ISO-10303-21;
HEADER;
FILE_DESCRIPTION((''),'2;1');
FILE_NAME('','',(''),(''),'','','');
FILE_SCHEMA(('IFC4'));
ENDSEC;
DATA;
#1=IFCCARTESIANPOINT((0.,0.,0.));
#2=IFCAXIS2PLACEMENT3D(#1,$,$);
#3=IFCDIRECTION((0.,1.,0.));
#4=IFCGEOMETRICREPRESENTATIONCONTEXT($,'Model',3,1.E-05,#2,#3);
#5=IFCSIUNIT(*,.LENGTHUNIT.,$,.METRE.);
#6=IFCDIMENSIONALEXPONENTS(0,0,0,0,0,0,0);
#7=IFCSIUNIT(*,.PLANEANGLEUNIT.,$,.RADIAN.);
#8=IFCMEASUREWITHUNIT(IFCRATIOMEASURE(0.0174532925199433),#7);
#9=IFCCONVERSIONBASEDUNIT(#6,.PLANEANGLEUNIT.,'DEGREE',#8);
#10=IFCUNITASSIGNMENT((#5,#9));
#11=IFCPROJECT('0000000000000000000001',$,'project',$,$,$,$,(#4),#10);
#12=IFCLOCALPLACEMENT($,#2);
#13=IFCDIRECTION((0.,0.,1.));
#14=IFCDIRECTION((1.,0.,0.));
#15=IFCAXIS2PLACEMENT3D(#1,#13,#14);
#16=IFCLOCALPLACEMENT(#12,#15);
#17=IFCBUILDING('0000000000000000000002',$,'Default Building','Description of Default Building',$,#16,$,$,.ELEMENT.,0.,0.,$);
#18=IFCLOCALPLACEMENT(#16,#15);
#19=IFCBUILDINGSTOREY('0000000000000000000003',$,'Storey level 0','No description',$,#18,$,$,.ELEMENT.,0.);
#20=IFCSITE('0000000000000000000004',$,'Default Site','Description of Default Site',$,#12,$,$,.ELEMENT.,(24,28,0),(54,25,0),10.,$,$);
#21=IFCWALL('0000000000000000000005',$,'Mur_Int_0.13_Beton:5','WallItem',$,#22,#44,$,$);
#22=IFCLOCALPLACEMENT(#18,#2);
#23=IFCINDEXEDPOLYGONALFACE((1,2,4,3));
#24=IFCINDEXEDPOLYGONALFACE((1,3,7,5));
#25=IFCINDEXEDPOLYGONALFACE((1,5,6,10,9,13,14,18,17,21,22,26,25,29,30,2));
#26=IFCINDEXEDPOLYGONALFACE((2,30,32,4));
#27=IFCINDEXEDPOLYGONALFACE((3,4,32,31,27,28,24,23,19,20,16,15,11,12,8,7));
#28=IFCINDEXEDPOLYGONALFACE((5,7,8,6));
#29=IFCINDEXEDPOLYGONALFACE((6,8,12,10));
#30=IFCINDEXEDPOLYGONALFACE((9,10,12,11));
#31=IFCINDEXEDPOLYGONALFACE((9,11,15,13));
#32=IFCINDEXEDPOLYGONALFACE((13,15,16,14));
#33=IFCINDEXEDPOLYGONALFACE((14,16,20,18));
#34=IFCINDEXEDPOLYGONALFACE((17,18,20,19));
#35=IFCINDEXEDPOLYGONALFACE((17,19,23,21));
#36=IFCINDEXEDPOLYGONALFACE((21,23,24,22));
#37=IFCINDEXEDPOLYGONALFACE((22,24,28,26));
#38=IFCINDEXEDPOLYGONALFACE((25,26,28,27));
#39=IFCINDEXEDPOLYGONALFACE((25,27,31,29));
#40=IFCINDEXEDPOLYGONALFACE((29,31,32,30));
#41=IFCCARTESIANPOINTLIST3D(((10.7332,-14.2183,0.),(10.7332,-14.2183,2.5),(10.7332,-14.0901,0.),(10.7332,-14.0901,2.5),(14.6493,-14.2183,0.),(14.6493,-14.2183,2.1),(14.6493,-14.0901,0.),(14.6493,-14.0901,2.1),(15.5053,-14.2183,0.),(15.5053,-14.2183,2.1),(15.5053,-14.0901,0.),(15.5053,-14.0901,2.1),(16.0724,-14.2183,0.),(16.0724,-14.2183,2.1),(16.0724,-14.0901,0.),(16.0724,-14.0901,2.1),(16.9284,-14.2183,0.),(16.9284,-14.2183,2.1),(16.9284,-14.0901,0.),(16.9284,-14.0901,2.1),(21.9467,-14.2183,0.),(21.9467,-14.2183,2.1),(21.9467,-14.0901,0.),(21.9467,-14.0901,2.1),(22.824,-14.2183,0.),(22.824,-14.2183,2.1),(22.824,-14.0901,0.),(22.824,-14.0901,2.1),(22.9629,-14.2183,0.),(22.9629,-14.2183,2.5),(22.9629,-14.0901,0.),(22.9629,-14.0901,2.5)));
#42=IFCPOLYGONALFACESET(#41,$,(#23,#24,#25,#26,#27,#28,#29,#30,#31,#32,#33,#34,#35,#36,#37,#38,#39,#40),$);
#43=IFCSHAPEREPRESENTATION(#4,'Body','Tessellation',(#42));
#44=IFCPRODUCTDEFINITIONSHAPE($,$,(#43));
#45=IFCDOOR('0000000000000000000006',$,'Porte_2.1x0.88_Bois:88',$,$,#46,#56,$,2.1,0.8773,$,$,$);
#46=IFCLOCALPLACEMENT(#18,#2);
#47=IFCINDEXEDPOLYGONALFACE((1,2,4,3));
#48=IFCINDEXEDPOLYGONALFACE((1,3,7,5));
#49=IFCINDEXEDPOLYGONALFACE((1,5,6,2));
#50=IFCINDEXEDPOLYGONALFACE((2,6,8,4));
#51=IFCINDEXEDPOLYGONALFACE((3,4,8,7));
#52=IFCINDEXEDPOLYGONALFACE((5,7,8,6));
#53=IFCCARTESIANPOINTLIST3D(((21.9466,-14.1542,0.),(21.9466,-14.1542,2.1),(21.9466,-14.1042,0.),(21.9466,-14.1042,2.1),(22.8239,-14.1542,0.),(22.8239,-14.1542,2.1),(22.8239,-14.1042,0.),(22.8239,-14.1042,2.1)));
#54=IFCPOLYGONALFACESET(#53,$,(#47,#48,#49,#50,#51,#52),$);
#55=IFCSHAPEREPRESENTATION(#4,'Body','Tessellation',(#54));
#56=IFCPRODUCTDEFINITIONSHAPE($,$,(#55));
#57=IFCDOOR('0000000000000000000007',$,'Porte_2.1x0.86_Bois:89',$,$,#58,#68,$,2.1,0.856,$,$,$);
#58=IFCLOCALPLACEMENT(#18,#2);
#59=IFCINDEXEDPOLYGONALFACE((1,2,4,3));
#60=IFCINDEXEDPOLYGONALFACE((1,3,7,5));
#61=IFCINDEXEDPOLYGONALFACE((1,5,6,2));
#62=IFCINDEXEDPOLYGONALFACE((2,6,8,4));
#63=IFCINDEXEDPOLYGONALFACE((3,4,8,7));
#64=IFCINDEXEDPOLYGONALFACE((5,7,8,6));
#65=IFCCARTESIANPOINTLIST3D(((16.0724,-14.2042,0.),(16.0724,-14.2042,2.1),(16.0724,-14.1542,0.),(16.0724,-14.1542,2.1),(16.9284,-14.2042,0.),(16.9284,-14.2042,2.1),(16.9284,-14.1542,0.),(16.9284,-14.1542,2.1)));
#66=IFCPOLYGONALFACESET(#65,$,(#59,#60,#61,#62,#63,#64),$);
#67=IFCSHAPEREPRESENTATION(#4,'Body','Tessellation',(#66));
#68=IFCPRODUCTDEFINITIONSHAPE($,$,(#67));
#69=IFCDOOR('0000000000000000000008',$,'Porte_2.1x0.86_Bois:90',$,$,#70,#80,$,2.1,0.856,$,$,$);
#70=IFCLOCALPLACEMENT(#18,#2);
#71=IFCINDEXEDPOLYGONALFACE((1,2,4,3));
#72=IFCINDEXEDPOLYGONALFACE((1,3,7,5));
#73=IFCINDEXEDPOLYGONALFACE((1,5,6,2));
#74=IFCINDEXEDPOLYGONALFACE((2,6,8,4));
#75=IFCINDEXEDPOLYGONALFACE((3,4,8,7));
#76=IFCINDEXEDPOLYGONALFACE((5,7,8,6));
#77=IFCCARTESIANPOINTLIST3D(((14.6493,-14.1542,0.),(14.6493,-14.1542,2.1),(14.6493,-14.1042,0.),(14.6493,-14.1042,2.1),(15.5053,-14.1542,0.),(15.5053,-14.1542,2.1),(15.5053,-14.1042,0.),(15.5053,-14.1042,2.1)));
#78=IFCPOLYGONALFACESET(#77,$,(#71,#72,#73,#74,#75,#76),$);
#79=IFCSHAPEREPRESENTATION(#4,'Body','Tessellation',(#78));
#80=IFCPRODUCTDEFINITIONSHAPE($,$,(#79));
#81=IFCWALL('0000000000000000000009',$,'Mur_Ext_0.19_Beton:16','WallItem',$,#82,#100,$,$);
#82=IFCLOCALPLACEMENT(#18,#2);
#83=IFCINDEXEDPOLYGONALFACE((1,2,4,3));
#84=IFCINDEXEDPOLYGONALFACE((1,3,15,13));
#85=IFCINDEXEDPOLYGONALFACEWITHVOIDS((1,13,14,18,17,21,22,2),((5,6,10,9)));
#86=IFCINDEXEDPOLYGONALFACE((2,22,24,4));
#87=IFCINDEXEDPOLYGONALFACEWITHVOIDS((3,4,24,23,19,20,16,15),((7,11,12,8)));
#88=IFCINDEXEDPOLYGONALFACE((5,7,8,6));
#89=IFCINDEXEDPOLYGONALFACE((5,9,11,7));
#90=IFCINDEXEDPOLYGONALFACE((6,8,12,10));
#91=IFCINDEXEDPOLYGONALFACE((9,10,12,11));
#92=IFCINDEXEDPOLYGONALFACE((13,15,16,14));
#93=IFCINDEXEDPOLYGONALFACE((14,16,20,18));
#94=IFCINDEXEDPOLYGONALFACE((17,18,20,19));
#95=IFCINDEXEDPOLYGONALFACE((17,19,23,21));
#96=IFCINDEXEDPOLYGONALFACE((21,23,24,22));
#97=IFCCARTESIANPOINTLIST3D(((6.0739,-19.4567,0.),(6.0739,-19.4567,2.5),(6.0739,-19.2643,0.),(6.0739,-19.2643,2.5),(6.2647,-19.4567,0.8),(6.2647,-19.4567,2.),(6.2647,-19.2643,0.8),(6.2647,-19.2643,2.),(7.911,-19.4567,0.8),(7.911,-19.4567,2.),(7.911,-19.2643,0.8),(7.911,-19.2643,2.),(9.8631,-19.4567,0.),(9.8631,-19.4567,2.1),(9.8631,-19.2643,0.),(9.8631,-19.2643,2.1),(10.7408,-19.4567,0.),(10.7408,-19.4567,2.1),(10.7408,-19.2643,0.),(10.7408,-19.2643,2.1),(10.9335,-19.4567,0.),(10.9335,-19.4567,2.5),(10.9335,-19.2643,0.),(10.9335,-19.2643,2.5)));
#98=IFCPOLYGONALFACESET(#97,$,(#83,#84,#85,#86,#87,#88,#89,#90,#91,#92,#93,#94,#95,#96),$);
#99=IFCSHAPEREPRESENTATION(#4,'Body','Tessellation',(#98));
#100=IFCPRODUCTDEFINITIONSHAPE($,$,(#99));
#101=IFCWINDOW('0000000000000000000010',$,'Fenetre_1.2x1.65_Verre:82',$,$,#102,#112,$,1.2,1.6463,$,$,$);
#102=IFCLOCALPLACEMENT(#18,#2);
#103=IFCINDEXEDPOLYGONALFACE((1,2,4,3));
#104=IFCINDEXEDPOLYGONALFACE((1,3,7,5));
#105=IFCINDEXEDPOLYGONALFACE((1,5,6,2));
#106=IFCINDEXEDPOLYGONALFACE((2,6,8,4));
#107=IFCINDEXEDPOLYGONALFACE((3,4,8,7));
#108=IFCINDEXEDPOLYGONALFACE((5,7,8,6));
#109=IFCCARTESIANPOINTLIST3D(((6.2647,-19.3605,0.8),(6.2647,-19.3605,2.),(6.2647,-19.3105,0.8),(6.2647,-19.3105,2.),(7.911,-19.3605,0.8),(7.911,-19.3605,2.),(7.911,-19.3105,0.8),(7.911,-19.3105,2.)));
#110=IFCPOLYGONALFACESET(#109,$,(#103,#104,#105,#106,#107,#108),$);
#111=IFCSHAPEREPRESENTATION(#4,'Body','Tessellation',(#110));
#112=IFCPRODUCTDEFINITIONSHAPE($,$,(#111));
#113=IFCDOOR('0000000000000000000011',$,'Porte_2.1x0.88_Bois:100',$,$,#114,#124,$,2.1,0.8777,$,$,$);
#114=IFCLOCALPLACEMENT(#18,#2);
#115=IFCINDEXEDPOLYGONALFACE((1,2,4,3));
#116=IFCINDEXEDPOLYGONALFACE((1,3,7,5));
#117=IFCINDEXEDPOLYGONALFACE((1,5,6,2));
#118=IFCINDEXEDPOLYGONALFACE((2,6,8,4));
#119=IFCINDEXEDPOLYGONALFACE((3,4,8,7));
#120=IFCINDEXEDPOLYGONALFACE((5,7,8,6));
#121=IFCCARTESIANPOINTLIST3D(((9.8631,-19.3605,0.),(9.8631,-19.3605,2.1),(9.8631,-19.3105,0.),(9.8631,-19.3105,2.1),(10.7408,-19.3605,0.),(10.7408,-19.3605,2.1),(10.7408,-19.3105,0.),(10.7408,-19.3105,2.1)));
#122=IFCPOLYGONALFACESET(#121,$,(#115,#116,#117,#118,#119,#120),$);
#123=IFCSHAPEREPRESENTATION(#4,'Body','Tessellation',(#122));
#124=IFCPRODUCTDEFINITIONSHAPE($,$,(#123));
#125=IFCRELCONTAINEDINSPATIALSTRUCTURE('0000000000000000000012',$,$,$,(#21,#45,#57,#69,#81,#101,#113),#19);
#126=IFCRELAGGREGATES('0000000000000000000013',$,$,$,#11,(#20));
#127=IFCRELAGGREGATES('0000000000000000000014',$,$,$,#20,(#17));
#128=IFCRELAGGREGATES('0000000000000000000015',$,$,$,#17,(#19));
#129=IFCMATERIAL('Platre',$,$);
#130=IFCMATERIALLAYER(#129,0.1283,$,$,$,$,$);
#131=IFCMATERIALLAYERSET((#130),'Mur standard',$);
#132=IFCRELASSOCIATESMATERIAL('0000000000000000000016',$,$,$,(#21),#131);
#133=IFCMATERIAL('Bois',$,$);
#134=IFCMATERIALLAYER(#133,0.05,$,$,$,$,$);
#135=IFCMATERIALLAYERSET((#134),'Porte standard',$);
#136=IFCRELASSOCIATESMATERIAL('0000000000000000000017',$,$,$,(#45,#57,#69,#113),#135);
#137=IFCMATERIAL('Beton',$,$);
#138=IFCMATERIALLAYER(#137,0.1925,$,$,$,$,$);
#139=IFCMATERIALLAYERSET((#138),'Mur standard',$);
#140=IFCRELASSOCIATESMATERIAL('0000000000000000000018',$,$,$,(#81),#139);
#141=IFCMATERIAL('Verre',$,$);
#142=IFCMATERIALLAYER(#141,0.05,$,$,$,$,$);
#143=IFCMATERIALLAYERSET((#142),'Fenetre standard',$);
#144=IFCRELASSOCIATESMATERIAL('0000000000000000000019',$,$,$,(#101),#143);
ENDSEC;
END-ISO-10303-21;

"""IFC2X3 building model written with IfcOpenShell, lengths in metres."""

from ifc_helpers import new_model, entity, si_unit, converted_unit, direction, frame, origin, origin_with_axes, place, context, project, spatial, polyline, outline, extrude, material, layer, layer_set, layer_usage, element, fill, save


model = new_model("IFC2X3")

# Units and contexts
model_context = context("Model", 3, precision=1e-05, world=origin(), true_north=direction((0.0, 1.0, 0.0)))
ifc_project = project(units=[si_unit("LENGTHUNIT", "METRE"), converted_unit("PLANEANGLEUNIT", "DEGREE", entity("IfcRatioMeasure", 0.0174532925199433), si_unit("PLANEANGLEUNIT", "RADIAN"), dimensions=[0, 0, 0, 0, 0, 0, 0])], contexts=[model_context])

# Site, building, storey
site_placement = place(None, origin())
site = spatial("IfcSite", under=ifc_project, at=site_placement, Name="Default Site", Description="Description of Default Site", CompositionType="ELEMENT", RefLatitude=(24, 28, 0), RefLongitude=(54, 25, 0), RefElevation=10.0)
building_placement = place(site_placement, origin_with_axes())
building = spatial("IfcBuilding", under=site, at=building_placement, Name="Default Building", Description="Description of Default Building", CompositionType="ELEMENT", ElevationOfRefHeight=0.0, ElevationOfTerrain=0.0)
storey_placement = place(building_placement, origin_with_axes())
storey = spatial("IfcBuildingStorey", under=building, at=storey_placement, Name="Storey level 0", Description="No description", CompositionType="ELEMENT", Elevation=0.0)

# Wall, openings, doors
ifc_material_1 = material(Name="Platre")
ifc_layer_1 = layer(ifc_material_1, 0.1283)
ifc_layer_set_1 = layer_set([ifc_layer_1], Name="Mur standard")
ifc_layer_usage_1 = layer_usage(ifc_layer_set_1, "AXIS2", "NEGATIVE", 0.1283)
wall_1_placement = place(storey_placement, frame((10.7332, -14.1542, 0.0), z_axis=(0.0, 0.0, 1.0), x_axis=(1.0, 0.0, 0.0)))
wall_1 = element("IfcWall", 1, at=wall_1_placement, inside=storey, material=ifc_layer_usage_1, Name="Mur_Int_0.13_Beton:5", Description="WallItem", context=model_context, shape_type="SweptSolid", body=[
    extrude(outline(polyline([(0.0, 0.0641), (0.0, -0.0641), (12.2297, -0.0641), (12.2297, 0.0641), (0.0, 0.0641)])), origin(), (0.0, 0.0, 1.0), 2.5),
])
opening_1_placement = place(storey_placement, frame((22.824, -14.09, 0.0), z_axis=(0.0, 0.0, 1.0), x_axis=(-1.0, 0.0, 0.0)))
opening_1 = element("IfcOpeningElement", 2, at=opening_1_placement, cuts=wall_1, context=model_context, shape_type="SweptSolid", body=[
    extrude(outline(polyline([(0.8773, 0.1783), (0.0, 0.1783), (0.0, -0.05), (0.8773, -0.05), (0.8773, 0.1783)])), origin(), (0.0, 0.0, 1.0), 2.1),
])
opening_2_placement = place(storey_placement, frame((16.0724, -14.09, 0.0), z_axis=(0.0, 0.0, 1.0), x_axis=(1.0, 0.0, 0.0)))
opening_2 = element("IfcOpeningElement", 3, at=opening_2_placement, cuts=wall_1, context=model_context, shape_type="SweptSolid", body=[
    extrude(outline(polyline([(0.0, -0.1783), (0.856, -0.1783), (0.856, 0.05), (0.0, 0.05), (0.0, -0.1783)])), origin(), (0.0, 0.0, 1.0), 2.1),
])
opening_3_placement = place(storey_placement, frame((15.5053, -14.09, 0.0), z_axis=(0.0, 0.0, 1.0), x_axis=(-1.0, 0.0, 0.0)))
opening_3 = element("IfcOpeningElement", 4, at=opening_3_placement, cuts=wall_1, context=model_context, shape_type="SweptSolid", body=[
    extrude(outline(polyline([(0.856, 0.1783), (0.0, 0.1783), (0.0, -0.05), (0.856, -0.05), (0.856, 0.1783)])), origin(), (0.0, 0.0, 1.0), 2.1),
])
ifc_material_2 = material(Name="Bois")
ifc_layer_2 = layer(ifc_material_2, 0.05)
ifc_layer_set_2 = layer_set([ifc_layer_2], Name="Porte standard")
ifc_layer_usage_2 = layer_usage(ifc_layer_set_2, "AXIS2", "NEGATIVE", 0.05)
door_1_placement = place(wall_1_placement, frame((12.0907, 0.0, 0.0), z_axis=(0.0, 0.0, 1.0), x_axis=(-1.0, 0.0, 0.0)))
door_1 = element("IfcDoor", 5, at=door_1_placement, inside=storey, material=ifc_layer_usage_2, Name="Porte_2.1x0.88_Bois:88", OverallHeight=2.1, OverallWidth=0.8773, context=model_context, shape_type="SweptSolid", body=[
    extrude(outline(polyline([(0.0, 0.0), (0.8773, 0.0), (0.8773, -0.05), (0.0, -0.05), (0.0, 0.0)])), origin(), (0.0, 0.0, 1.0), 2.1),
])
fill(opening_1, door_1)
door_2_placement = place(wall_1_placement, frame((5.3392, 0.0, 0.0), z_axis=(0.0, 0.0, 1.0), x_axis=(1.0, 0.0, 0.0)))
door_2 = element("IfcDoor", 6, at=door_2_placement, inside=storey, material=ifc_layer_usage_2, Name="Porte_2.1x0.86_Bois:89", OverallHeight=2.1, OverallWidth=0.856, context=model_context, shape_type="SweptSolid", body=[
    extrude(outline(polyline([(0.0, 0.0), (0.856, 0.0), (0.856, -0.05), (0.0, -0.05), (0.0, 0.0)])), origin(), (0.0, 0.0, 1.0), 2.1),
])
fill(opening_2, door_2)
door_3_placement = place(wall_1_placement, frame((4.7721, 0.0, 0.0), z_axis=(0.0, 0.0, 1.0), x_axis=(-1.0, 0.0, 0.0)))
door_3 = element("IfcDoor", 7, at=door_3_placement, inside=storey, material=ifc_layer_usage_2, Name="Porte_2.1x0.86_Bois:90", OverallHeight=2.1, OverallWidth=0.856, context=model_context, shape_type="SweptSolid", body=[
    extrude(outline(polyline([(0.0, 0.0), (0.856, 0.0), (0.856, -0.05), (0.0, -0.05), (0.0, 0.0)])), origin(), (0.0, 0.0, 1.0), 2.1),
])
fill(opening_3, door_3)

# Wall, openings, window, door
ifc_material_3 = material(Name="Beton")
ifc_layer_3 = layer(ifc_material_3, 0.1925)
ifc_layer_set_3 = layer_set([ifc_layer_3], Name="Mur standard")
ifc_layer_usage_3 = layer_usage(ifc_layer_set_3, "AXIS2", "NEGATIVE", 0.1925)
wall_2_placement = place(storey_placement, frame((6.0739, -19.3605, 0.0), z_axis=(0.0, 0.0, 1.0), x_axis=(1.0, 0.0, 0.0)))
wall_2 = element("IfcWall", 8, at=wall_2_placement, inside=storey, material=ifc_layer_usage_3, Name="Mur_Ext_0.19_Beton:16", Description="WallItem", context=model_context, shape_type="SweptSolid", body=[
    extrude(outline(polyline([(0.0, 0.0962), (0.0, -0.0962), (4.8596, -0.0962), (4.8596, 0.0962), (0.0, 0.0962)])), origin(), (0.0, 0.0, 1.0), 2.5),
])
opening_4_placement = place(storey_placement, frame((7.911, -19.2642, 0.8), z_axis=(0.0, 0.0, 1.0), x_axis=(-1.0, 0.0, 0.0)))
opening_4 = element("IfcOpeningElement", 9, at=opening_4_placement, cuts=wall_2, context=model_context, shape_type="SweptSolid", body=[
    extrude(outline(polyline([(1.6463, 0.2425), (0.0, 0.2425), (0.0, -0.05), (1.6463, -0.05), (1.6463, 0.2425)])), origin(), (0.0, 0.0, 1.0), 1.2),
])
opening_5_placement = place(storey_placement, frame((10.7408, -19.4567, 0.0), z_axis=(0.0, 0.0, 1.0), x_axis=(-1.0, 0.0, 0.0)))
opening_5 = element("IfcOpeningElement", 10, at=opening_5_placement, cuts=wall_2, context=model_context, shape_type="SweptSolid", body=[
    extrude(outline(polyline([(0.8777, 0.05), (0.0, 0.05), (0.0, -0.2425), (0.8777, -0.2425), (0.8777, 0.05)])), origin(), (0.0, 0.0, 1.0), 2.1),
])
ifc_material_4 = material(Name="Verre")
ifc_layer_4 = layer(ifc_material_4, 0.05)
ifc_layer_set_4 = layer_set([ifc_layer_4], Name="Fenetre standard")
ifc_layer_usage_4 = layer_usage(ifc_layer_set_4, "AXIS2", "NEGATIVE", 0.05)
window_placement = place(wall_2_placement, frame((1.8371, 0.0, 0.8), z_axis=(0.0, 0.0, 1.0), x_axis=(-1.0, 0.0, 0.0)))
window = element("IfcWindow", 11, at=window_placement, inside=storey, material=ifc_layer_usage_4, Name="Fenetre_1.2x1.65_Verre:82", OverallHeight=1.2, OverallWidth=1.6463, context=model_context, shape_type="SweptSolid", body=[
    extrude(outline(polyline([(0.0, 0.0), (1.6463, 0.0), (1.6463, -0.05), (0.0, -0.05), (0.0, 0.0)])), origin(), (0.0, 0.0, 1.0), 1.2),
])
fill(opening_4, window)
door_4_placement = place(wall_2_placement, frame((4.6669, 0.0, 0.0), z_axis=(0.0, 0.0, 1.0), x_axis=(-1.0, 0.0, 0.0)))
door_4 = element("IfcDoor", 12, at=door_4_placement, inside=storey, material=ifc_layer_usage_2, Name="Porte_2.1x0.88_Bois:100", OverallHeight=2.1, OverallWidth=0.8777, context=model_context, shape_type="SweptSolid", body=[
    extrude(outline(polyline([(0.0, 0.0), (0.8777, 0.0), (0.8777, -0.05), (0.0, -0.05), (0.0, 0.0)])), origin(), (0.0, 0.0, 1.0), 2.1),
])
fill(opening_5, door_4)

save(model, "model.ifc")
